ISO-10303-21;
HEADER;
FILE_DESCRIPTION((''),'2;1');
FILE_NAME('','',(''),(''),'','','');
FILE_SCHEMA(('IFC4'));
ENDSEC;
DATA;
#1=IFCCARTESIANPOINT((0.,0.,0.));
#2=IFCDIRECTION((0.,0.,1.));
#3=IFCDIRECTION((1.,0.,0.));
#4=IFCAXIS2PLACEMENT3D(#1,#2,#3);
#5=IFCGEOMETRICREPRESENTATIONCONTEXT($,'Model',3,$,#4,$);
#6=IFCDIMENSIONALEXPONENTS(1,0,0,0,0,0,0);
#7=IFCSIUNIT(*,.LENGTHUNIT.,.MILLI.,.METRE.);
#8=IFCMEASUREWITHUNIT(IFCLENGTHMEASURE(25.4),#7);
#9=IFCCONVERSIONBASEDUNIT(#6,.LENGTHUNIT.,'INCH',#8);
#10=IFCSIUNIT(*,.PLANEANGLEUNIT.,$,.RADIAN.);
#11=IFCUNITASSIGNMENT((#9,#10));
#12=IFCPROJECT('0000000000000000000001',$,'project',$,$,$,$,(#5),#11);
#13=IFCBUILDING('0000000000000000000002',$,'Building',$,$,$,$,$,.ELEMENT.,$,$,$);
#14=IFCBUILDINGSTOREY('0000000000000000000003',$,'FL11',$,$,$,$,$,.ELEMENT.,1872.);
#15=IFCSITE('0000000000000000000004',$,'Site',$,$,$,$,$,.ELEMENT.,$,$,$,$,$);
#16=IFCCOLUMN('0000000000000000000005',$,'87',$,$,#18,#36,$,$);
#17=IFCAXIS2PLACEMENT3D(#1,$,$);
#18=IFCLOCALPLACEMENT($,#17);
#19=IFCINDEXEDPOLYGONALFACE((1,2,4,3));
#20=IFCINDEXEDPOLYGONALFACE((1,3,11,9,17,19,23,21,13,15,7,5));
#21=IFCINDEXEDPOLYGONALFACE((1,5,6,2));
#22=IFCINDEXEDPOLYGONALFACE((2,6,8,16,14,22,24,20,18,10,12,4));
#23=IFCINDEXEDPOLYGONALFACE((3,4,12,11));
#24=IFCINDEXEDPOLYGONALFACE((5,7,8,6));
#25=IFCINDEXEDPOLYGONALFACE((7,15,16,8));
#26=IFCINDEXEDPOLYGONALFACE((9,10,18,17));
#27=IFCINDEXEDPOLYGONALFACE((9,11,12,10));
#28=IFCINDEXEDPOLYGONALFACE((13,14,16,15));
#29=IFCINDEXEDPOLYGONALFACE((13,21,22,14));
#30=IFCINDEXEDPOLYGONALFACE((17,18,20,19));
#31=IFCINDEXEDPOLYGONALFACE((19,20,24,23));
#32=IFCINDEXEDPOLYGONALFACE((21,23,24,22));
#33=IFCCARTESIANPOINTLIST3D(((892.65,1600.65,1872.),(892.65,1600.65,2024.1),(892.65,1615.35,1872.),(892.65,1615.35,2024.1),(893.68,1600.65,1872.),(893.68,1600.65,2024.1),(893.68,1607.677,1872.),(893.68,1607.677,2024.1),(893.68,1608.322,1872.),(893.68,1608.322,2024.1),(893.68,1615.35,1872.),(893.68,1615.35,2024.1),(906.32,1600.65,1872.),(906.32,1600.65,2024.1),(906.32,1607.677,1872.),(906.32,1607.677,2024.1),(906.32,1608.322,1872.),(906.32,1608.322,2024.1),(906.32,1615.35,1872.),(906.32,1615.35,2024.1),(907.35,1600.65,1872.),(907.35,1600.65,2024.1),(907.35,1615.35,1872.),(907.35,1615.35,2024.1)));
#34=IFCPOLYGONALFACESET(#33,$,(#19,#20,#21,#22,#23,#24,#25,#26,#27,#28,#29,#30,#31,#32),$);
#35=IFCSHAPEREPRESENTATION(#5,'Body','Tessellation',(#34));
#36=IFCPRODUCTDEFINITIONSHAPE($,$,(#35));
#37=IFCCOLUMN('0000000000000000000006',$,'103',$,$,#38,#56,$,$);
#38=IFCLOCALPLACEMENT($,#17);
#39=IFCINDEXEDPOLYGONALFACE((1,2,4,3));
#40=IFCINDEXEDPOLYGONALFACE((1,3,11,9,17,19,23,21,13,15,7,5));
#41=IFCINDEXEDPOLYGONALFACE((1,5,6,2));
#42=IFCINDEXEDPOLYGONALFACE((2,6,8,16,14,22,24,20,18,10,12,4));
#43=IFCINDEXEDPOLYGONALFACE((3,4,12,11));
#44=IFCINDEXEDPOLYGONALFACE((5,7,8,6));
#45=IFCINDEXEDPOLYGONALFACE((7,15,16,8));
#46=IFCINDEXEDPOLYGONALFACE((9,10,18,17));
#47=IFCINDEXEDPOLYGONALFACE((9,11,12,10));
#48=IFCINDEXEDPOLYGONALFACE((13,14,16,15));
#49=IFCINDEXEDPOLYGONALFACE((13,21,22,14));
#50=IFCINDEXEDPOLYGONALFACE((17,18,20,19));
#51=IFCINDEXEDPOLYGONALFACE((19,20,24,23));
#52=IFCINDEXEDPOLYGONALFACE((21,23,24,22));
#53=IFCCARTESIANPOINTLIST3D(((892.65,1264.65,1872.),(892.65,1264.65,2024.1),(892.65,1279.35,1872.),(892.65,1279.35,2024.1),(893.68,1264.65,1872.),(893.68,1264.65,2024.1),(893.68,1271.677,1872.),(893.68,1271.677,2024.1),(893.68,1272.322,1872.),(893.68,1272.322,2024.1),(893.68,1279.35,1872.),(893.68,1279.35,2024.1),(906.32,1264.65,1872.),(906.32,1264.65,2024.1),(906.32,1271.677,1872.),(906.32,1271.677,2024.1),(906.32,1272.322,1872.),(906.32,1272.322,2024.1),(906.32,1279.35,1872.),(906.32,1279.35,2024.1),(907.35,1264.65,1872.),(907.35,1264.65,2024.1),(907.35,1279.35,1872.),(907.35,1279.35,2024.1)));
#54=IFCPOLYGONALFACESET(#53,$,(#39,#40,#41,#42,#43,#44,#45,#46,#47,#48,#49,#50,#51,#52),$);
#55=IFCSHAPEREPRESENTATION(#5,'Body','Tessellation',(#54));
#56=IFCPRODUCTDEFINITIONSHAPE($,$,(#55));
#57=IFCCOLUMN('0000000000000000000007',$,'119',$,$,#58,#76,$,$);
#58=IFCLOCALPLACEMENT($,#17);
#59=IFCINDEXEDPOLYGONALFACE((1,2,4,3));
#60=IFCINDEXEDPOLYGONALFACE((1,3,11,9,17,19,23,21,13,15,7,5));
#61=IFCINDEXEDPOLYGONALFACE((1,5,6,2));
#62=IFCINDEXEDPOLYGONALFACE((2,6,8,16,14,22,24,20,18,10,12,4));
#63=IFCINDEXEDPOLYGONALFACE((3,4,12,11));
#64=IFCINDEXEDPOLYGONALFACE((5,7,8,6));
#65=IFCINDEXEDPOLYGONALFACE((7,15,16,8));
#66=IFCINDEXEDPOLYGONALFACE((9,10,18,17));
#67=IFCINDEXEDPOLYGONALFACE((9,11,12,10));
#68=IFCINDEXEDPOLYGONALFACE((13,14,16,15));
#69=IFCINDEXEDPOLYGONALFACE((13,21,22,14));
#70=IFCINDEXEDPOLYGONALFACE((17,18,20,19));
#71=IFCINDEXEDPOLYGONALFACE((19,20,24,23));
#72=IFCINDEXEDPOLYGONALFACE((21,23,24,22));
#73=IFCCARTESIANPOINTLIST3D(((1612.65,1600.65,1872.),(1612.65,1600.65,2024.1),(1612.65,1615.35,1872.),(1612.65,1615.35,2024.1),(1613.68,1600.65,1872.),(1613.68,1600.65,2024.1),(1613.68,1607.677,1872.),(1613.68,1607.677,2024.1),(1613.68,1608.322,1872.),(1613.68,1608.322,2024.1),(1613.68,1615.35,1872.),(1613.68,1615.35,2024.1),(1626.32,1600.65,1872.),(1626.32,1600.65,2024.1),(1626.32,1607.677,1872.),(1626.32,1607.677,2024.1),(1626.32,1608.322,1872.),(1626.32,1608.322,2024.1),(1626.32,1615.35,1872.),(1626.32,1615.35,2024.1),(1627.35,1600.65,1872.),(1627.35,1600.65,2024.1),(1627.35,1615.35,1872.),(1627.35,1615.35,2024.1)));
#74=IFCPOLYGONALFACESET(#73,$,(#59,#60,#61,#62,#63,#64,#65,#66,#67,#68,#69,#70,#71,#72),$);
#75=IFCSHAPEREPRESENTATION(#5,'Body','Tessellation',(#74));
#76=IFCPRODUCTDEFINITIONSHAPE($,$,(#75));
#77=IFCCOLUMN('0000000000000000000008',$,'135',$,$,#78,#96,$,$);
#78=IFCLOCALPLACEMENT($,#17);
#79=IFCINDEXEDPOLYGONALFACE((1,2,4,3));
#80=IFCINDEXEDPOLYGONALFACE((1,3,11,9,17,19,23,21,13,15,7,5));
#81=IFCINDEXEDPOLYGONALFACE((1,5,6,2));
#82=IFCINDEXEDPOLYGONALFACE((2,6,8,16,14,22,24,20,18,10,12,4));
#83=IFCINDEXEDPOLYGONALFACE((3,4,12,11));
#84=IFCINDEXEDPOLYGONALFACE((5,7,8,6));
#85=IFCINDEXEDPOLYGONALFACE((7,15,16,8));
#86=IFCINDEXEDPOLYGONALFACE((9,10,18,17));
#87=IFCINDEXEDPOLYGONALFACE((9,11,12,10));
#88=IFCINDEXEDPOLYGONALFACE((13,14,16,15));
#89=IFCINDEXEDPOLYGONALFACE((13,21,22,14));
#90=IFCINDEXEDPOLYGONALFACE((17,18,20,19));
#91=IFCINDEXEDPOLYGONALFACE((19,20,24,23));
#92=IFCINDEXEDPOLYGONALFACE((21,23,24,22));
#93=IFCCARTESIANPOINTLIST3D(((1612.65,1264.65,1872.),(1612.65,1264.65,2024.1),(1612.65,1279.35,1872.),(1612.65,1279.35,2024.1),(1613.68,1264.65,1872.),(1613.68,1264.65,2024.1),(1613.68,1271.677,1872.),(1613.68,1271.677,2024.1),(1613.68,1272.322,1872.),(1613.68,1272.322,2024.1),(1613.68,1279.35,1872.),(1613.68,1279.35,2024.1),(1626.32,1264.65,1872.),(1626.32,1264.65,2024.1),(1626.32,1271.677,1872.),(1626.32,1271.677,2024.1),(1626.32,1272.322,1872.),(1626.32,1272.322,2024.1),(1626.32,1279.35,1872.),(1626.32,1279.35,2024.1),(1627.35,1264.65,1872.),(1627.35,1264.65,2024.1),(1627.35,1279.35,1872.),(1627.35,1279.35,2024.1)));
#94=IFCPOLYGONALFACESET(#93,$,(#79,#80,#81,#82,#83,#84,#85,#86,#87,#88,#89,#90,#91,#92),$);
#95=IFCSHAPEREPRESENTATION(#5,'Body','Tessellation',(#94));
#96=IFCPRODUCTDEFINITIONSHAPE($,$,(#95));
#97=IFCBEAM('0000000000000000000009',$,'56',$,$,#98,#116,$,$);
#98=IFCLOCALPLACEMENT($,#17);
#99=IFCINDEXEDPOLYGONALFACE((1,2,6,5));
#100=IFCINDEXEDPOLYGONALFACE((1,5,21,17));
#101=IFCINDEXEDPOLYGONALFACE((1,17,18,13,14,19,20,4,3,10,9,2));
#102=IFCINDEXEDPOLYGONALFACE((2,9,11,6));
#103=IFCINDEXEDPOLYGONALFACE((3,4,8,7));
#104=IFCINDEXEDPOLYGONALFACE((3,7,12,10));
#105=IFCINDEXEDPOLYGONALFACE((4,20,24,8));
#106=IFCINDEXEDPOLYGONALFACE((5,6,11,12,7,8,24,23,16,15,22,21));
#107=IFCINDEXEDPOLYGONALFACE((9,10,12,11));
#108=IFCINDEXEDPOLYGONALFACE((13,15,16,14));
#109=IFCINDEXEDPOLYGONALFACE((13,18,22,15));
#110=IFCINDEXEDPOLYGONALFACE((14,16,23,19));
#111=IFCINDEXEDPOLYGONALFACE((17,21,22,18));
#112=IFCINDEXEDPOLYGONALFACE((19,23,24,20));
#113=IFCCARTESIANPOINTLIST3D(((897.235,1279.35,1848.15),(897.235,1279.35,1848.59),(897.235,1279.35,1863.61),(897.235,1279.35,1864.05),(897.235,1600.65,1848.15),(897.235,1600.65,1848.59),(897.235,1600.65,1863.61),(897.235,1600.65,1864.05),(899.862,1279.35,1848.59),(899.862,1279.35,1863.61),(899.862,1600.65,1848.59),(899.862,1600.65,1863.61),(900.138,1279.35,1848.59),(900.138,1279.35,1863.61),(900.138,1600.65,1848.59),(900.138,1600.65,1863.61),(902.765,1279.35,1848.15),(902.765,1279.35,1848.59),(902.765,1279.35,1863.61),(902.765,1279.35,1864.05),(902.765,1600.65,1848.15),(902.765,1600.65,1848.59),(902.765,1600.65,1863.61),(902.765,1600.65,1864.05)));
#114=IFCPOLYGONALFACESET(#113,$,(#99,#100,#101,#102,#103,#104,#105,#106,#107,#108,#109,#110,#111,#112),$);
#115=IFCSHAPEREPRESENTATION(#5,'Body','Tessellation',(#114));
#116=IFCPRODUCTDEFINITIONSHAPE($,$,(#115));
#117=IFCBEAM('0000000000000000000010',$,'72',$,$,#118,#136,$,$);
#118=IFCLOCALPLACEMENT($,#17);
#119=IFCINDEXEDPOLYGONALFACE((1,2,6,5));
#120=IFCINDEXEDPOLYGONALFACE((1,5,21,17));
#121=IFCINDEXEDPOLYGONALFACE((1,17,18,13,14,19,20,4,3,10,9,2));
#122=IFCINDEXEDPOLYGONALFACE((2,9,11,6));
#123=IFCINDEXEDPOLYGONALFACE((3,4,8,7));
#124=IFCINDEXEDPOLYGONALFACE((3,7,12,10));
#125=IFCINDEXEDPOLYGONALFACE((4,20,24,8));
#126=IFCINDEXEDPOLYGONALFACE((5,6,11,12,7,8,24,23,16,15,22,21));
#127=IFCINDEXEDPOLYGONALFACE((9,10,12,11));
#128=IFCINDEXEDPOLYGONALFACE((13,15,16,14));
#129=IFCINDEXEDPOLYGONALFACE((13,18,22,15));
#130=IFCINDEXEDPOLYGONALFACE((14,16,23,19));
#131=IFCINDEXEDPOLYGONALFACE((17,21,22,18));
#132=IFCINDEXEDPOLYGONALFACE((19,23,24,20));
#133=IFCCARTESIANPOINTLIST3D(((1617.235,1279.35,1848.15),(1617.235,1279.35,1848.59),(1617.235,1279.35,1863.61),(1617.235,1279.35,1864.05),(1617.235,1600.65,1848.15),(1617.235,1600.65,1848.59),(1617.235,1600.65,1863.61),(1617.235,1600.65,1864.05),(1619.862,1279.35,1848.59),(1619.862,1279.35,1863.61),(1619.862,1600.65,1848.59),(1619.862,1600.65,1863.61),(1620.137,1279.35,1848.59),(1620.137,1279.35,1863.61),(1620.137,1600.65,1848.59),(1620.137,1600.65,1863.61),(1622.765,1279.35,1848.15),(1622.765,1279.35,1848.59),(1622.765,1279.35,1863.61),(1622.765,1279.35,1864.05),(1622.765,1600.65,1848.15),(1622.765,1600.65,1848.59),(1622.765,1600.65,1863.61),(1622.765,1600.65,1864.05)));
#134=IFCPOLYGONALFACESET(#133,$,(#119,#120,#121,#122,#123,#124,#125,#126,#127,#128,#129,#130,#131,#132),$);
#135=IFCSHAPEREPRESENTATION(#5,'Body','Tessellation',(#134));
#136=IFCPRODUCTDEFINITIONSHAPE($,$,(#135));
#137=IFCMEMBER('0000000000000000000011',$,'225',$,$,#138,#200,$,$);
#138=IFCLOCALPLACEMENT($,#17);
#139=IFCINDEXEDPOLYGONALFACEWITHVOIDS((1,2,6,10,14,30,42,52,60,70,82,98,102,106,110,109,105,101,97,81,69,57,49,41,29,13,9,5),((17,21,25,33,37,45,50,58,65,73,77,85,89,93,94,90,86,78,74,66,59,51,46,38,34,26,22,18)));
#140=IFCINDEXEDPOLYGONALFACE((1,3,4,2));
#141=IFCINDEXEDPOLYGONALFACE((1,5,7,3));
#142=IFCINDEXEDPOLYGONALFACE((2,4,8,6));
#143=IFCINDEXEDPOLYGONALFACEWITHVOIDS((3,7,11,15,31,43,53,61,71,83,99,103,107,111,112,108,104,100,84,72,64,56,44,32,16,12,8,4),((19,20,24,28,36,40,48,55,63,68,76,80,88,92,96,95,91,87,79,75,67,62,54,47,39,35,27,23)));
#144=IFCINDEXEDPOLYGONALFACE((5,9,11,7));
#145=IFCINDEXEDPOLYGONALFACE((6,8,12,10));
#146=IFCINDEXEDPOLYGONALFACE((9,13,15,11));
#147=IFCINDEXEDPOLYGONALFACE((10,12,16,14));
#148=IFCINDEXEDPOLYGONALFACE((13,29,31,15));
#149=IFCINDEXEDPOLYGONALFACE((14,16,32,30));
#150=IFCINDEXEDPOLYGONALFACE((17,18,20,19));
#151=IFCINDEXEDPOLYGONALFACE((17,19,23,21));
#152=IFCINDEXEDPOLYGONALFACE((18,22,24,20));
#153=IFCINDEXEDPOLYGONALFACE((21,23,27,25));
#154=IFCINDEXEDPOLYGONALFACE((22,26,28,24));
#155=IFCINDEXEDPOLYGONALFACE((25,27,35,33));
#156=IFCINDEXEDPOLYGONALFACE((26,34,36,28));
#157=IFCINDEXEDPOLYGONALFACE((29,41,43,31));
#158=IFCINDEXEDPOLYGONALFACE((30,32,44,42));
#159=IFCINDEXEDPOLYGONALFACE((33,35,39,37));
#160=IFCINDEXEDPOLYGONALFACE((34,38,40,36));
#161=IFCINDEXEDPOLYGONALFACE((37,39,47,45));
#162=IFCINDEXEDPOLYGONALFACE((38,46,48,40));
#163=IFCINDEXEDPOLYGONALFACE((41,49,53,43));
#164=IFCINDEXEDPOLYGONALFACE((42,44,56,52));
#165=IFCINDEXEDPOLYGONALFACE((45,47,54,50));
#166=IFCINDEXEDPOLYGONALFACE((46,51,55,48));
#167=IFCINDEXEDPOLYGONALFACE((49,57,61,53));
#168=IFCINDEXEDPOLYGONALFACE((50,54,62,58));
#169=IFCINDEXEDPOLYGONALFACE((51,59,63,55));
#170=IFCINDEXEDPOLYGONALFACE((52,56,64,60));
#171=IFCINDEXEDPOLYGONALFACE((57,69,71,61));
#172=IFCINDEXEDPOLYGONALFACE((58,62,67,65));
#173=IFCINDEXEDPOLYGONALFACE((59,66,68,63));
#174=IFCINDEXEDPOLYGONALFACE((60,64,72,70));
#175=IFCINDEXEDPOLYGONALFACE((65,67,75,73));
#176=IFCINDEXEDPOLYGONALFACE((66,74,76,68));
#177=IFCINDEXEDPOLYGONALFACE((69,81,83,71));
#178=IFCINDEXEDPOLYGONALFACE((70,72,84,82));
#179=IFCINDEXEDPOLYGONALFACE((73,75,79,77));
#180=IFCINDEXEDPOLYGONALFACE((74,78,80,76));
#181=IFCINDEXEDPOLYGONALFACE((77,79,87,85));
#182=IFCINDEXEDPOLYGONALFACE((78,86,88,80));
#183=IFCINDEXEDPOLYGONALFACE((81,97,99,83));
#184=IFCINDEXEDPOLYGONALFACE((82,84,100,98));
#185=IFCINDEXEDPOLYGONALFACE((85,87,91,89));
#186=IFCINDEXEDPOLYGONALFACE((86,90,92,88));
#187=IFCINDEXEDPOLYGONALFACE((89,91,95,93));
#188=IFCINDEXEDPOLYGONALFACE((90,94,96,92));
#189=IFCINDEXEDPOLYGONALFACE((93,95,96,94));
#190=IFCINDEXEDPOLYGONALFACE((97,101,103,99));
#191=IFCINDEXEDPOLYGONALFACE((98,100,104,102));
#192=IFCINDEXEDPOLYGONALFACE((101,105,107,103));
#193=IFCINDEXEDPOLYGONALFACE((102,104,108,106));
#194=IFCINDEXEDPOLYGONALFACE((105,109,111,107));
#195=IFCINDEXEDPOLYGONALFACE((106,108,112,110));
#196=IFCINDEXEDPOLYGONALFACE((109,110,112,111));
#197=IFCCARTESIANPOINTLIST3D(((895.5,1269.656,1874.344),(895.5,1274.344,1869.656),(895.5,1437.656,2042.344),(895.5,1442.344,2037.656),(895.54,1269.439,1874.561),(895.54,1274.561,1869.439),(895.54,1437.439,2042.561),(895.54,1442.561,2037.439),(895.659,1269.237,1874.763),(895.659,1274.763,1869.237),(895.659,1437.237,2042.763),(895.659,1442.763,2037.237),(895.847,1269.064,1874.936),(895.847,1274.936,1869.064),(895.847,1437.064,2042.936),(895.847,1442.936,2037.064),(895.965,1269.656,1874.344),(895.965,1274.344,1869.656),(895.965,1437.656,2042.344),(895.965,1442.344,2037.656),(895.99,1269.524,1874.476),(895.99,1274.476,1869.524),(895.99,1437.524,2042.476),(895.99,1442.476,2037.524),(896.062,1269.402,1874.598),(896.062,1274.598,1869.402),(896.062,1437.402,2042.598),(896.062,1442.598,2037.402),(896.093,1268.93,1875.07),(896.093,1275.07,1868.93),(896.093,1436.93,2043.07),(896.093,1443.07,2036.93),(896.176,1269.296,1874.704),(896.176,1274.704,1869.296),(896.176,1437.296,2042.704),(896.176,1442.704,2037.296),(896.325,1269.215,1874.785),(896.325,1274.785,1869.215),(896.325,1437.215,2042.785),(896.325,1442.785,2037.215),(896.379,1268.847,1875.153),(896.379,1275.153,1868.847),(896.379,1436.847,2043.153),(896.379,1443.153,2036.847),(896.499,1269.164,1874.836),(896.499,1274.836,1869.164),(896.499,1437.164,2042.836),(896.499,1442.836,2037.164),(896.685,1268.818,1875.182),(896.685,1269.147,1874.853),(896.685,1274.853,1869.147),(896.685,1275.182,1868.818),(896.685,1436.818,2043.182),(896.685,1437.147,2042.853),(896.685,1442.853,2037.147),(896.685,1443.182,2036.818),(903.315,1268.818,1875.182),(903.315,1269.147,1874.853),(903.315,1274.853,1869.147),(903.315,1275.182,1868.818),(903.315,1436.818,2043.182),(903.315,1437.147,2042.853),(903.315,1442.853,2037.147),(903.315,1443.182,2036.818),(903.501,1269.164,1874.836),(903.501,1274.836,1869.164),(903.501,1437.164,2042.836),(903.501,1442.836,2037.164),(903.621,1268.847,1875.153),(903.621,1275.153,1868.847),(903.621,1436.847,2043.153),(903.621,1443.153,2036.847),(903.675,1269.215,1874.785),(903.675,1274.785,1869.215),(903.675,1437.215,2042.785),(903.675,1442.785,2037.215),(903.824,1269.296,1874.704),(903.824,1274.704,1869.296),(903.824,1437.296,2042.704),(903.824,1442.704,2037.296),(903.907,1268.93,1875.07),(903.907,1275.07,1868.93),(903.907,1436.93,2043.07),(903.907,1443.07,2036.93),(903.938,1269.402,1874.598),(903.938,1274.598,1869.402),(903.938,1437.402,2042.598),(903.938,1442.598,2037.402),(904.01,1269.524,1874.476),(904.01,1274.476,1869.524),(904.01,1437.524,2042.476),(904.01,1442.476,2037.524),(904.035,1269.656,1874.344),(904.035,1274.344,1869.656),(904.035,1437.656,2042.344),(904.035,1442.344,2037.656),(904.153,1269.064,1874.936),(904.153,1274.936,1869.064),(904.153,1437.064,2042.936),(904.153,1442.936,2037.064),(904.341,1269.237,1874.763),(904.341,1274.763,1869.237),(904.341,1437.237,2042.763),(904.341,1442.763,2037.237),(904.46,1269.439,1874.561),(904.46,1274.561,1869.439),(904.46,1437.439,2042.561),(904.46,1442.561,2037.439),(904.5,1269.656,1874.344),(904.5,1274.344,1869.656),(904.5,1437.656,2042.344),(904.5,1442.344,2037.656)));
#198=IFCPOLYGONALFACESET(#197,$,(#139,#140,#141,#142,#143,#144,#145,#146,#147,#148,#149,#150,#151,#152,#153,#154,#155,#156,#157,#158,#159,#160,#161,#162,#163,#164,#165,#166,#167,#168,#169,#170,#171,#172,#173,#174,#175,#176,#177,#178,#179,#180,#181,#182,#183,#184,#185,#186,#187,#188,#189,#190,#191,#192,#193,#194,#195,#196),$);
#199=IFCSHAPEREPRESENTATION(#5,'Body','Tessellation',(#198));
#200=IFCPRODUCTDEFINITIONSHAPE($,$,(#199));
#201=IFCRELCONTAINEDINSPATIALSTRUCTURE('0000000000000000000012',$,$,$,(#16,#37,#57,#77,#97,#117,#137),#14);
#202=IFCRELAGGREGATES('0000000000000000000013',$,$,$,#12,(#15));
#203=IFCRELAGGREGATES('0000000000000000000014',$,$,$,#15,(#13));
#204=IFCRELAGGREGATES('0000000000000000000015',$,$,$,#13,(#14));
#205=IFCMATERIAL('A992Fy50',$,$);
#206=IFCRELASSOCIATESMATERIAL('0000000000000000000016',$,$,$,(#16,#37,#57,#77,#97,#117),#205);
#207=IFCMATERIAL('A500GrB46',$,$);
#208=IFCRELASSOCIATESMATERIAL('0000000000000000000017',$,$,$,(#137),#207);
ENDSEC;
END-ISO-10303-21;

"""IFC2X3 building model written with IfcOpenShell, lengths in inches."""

from ifc_helpers import new_model, entity, si_unit, converted_unit, frame, origin_with_axes, origin_2d_with_axis, place, context, project, spatial, hollow_rectangle, i_section, transform_2d, derived_profile, extrude, material, element, save


model = new_model("IFC2X3")

# Units and contexts
model_context = context("Model", 3, world=origin_with_axes())
ifc_project = project(units=[converted_unit("LENGTHUNIT", "INCH", entity("IfcLengthMeasure", 25.4), si_unit("LENGTHUNIT", "METRE", prefix="MILLI"), dimensions=[1, 0, 0, 0, 0, 0, 0]), si_unit("PLANEANGLEUNIT", "RADIAN")], contexts=[model_context])

# Site, building, storey
site = spatial("IfcSite", under=ifc_project, Name="Site", CompositionType="ELEMENT")
building = spatial("IfcBuilding", under=site, Name="Building", CompositionType="ELEMENT")
storey = spatial("IfcBuildingStorey", under=building, Name="FL11", CompositionType="ELEMENT", Elevation=1872.0)

# Columns
ifc_material_1 = material(Name="A992Fy50")
for number, where, z_axis, x_axis, name in (
    (1, (900.0, 1608.0, 1872.0), (0.0, 0.0, 1.0), (0.0, -1.0, 0.0), "87"),
    (2, (900.0, 1272.0, 1872.0), (0.0, 0.0, 1.0), (0.0, -1.0, 0.0), "103"),
    (3, (1620.0, 1608.0, 1872.0), (0.0, 0.0, 1.0), (0.0, -1.0, 0.0), "119"),
    (4, (1620.0, 1272.0, 1872.0), (0.0, 0.0, 1.0), (0.0, -1.0, 0.0), "135"),
):
    element("IfcColumn", number, at=place(None, frame(where, z_axis=z_axis, x_axis=x_axis)), inside=storey, material=ifc_material_1, Name=name, context=model_context, shape_type="SweptSolid", body=[
        extrude(i_section(OverallWidth=14.7, OverallDepth=14.7, WebThickness=0.645, FlangeThickness=1.03, at=origin_2d_with_axis()), origin_with_axes(), (0.0, 0.0, 1.0), 152.1),
    ])

# Beams
for number, where, z_axis, x_axis, name in (
    (5, (900.0, 1279.35, 1872.0), (0.0, 1.0, 0.0), (-1.0, 0.0, 0.0), "56"),
    (6, (1620.0, 1279.35, 1872.0), (0.0, 1.0, 0.0), (-1.0, 0.0, 0.0), "72"),
):
    element("IfcBeam", number, at=place(None, frame(where, z_axis=z_axis, x_axis=x_axis)), inside=storey, material=ifc_material_1, Name=name, context=model_context, shape_type="SweptSolid", body=[
        extrude(derived_profile(i_section(OverallWidth=5.53, OverallDepth=15.9, WebThickness=0.275, FlangeThickness=0.44, at=origin_2d_with_axis()), transform_2d((0.0, -7.95))), origin_with_axes(), (0.0, 0.0, 1.0), 321.3),
    ])

# Member
ifc_material_2 = material(Name="A500GrB46")
for number, where, z_axis, x_axis, name in (
    (7, (900.0, 1272.0, 1872.0), (0.0, 0.707107, 0.707107), (-1.0, 0.0, 0.0), "225"),
):
    element("IfcMember", number, at=place(None, frame(where, z_axis=z_axis, x_axis=x_axis)), inside=storey, material=ifc_material_2, Name=name, context=model_context, shape_type="SweptSolid", body=[
        extrude(hollow_rectangle(XDim=9.0, YDim=9.0, WallThickness=0.465, InnerFilletRadius=0.72, OuterFilletRadius=1.185, at=origin_2d_with_axis()), origin_with_axes(), (0.0, 0.0, 1.0), 237.588),
    ])

save(model, "model.ifc")
